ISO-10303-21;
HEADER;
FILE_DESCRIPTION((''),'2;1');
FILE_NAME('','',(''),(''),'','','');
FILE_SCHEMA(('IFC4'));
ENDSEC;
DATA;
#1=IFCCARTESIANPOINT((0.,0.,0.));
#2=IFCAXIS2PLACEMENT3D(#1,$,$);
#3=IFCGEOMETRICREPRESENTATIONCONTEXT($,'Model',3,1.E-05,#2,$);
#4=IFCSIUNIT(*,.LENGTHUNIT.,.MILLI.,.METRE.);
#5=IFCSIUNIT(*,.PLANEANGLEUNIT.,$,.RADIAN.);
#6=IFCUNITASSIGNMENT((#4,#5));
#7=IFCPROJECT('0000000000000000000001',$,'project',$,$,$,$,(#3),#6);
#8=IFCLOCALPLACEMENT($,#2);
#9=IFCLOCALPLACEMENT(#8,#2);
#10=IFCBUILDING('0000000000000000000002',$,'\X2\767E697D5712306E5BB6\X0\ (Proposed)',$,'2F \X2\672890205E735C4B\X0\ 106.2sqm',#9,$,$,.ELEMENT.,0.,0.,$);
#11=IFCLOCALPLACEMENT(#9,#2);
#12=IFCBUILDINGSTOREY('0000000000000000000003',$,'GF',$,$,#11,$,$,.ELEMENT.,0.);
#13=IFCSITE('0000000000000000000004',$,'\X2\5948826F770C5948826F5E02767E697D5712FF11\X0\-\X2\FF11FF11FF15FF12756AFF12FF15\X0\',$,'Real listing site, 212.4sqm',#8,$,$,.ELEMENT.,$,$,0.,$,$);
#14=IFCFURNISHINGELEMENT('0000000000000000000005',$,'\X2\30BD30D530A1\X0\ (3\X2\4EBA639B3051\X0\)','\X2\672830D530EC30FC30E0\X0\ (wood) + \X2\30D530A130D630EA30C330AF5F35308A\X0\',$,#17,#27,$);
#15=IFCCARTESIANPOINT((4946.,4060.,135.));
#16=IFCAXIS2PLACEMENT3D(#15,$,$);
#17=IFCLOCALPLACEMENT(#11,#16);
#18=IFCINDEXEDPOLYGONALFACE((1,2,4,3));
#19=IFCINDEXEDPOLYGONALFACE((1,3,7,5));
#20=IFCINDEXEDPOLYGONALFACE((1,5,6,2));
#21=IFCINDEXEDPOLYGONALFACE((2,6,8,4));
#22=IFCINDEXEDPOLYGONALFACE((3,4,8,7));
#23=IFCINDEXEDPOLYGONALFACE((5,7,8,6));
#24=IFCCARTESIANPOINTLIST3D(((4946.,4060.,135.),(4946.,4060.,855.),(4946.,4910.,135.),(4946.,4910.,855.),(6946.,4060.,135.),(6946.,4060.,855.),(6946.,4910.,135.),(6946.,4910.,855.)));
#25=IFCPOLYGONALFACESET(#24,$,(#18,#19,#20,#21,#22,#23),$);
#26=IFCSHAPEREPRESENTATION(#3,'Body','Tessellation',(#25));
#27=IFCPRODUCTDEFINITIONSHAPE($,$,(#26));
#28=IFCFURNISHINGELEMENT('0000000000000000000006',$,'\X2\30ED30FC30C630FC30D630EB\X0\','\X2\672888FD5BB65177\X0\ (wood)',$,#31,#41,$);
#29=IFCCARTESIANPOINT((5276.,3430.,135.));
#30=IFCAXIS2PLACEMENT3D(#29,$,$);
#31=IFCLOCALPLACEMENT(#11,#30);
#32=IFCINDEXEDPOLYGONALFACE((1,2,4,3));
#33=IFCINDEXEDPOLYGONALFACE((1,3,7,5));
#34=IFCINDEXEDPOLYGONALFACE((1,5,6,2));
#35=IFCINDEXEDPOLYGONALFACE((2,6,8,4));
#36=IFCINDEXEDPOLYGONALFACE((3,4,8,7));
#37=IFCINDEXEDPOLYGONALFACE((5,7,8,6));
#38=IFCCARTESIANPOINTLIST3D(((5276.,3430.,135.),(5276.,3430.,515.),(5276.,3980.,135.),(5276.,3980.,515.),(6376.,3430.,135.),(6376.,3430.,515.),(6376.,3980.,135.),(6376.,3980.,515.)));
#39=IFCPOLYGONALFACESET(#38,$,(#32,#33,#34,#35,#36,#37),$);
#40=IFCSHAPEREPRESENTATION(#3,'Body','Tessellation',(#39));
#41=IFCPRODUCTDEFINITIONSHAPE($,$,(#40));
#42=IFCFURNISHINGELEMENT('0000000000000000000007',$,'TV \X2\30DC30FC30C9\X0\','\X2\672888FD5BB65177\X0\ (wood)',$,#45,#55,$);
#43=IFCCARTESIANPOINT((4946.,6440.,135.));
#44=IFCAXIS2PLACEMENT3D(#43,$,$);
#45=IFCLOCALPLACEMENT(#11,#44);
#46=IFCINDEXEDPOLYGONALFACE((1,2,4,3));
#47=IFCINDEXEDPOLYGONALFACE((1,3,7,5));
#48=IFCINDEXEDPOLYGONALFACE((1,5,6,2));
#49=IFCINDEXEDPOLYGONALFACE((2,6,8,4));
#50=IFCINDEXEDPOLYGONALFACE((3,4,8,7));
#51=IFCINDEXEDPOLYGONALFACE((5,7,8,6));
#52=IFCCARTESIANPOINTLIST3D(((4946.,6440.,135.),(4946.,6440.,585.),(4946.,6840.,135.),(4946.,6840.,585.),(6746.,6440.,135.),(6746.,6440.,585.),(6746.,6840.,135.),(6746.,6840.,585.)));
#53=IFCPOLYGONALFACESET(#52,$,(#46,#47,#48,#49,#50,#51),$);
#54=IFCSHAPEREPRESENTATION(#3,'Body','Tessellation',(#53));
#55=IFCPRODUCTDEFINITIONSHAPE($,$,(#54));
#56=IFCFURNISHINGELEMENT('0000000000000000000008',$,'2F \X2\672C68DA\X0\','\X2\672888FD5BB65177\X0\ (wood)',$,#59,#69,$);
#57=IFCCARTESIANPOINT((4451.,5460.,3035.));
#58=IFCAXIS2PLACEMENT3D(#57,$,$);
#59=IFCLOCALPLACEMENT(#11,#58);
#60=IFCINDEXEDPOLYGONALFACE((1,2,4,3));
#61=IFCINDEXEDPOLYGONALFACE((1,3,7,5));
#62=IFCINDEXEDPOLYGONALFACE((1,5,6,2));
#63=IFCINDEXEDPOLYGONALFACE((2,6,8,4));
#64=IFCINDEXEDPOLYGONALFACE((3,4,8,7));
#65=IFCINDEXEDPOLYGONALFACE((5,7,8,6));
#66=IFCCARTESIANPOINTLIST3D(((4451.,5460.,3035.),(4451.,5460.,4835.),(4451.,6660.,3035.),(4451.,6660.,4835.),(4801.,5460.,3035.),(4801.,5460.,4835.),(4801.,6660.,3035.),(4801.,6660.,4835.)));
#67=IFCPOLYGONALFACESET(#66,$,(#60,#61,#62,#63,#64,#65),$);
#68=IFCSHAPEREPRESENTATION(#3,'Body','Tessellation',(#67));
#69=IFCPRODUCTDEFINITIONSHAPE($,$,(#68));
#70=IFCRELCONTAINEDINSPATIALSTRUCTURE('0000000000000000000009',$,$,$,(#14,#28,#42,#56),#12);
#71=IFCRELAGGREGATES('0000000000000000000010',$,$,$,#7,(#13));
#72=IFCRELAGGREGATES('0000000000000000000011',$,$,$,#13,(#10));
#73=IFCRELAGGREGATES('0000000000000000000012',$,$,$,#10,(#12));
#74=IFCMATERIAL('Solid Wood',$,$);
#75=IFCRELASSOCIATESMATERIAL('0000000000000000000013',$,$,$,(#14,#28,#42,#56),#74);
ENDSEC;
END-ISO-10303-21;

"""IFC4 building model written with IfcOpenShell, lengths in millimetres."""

from ifc_helpers import new_model, si_unit, frame, frame_2d, origin, place, context, project, spatial, rectangle, extrude, material, element, save


model = new_model("IFC4")

# Units and contexts
model_context = context("Model", 3, precision=1e-05, world=origin())
ifc_project = project(units=[si_unit("LENGTHUNIT", "METRE", prefix="MILLI"), si_unit("PLANEANGLEUNIT", "RADIAN")], contexts=[model_context])

# Site, building, storey
site_placement = place(None, origin())
site = spatial("IfcSite", under=ifc_project, at=site_placement, Name="奈良県奈良市百楽園１-１１５２番２５", ObjectType="Real listing site, 212.4sqm", CompositionType="ELEMENT", RefElevation=0.0)
building_placement = place(site_placement, origin())
building = spatial("IfcBuilding", under=site, at=building_placement, Name="百楽園の家 (Proposed)", ObjectType="2F 木造平屋 106.2sqm", CompositionType="ELEMENT", ElevationOfRefHeight=0.0, ElevationOfTerrain=0.0)
storey_placement = place(building_placement, origin())
storey = spatial("IfcBuildingStorey", under=building, at=storey_placement, Name="GF", CompositionType="ELEMENT", Elevation=0.0)

# Shared definitions
ifc_material_1 = material(Name="Solid Wood")

# Furnishing elements
furnishing_1_placement = place(storey_placement, frame((4946.0, 4060.0, 135.0)))
element("IfcFurnishingElement", 1, at=furnishing_1_placement, inside=storey, material=ifc_material_1, Name="ソファ (3人掛け)", Description="木フレーム (wood) + ファブリック張り", context=model_context, shape_type="SweptSolid", body=[
    extrude(rectangle(XDim=2000.0, YDim=850.0, at=frame_2d((1000.0, 425.0))), frame((4946.0, 4060.0, 135.0)), (0.0, 0.0, 1.0), 720.0),
])
furnishing_2_placement = place(storey_placement, frame((5276.0, 3430.0, 135.0)))
element("IfcFurnishingElement", 2, at=furnishing_2_placement, inside=storey, material=ifc_material_1, Name="ローテーブル", Description="木製家具 (wood)", context=model_context, shape_type="SweptSolid", body=[
    extrude(rectangle(XDim=1100.0, YDim=550.0, at=frame_2d((550.0, 275.0))), frame((5276.0, 3430.0, 135.0)), (0.0, 0.0, 1.0), 380.0),
])
furnishing_3_placement = place(storey_placement, frame((4946.0, 6440.0, 135.0)))
element("IfcFurnishingElement", 3, at=furnishing_3_placement, inside=storey, material=ifc_material_1, Name="TV ボード", Description="木製家具 (wood)", context=model_context, shape_type="SweptSolid", body=[
    extrude(rectangle(XDim=1800.0, YDim=400.0, at=frame_2d((900.0, 200.0))), frame((4946.0, 6440.0, 135.0)), (0.0, 0.0, 1.0), 450.0),
])
furnishing_4_placement = place(storey_placement, frame((4451.0, 5460.0, 3035.0)))
element("IfcFurnishingElement", 4, at=furnishing_4_placement, inside=storey, material=ifc_material_1, Name="2F 本棚", Description="木製家具 (wood)", context=model_context, shape_type="SweptSolid", body=[
    extrude(rectangle(XDim=350.0, YDim=1200.0, at=frame_2d((175.0, 600.0))), frame((4451.0, 5460.0, 3035.0)), (0.0, 0.0, 1.0), 1800.0),
])

save(model, "model.ifc")
